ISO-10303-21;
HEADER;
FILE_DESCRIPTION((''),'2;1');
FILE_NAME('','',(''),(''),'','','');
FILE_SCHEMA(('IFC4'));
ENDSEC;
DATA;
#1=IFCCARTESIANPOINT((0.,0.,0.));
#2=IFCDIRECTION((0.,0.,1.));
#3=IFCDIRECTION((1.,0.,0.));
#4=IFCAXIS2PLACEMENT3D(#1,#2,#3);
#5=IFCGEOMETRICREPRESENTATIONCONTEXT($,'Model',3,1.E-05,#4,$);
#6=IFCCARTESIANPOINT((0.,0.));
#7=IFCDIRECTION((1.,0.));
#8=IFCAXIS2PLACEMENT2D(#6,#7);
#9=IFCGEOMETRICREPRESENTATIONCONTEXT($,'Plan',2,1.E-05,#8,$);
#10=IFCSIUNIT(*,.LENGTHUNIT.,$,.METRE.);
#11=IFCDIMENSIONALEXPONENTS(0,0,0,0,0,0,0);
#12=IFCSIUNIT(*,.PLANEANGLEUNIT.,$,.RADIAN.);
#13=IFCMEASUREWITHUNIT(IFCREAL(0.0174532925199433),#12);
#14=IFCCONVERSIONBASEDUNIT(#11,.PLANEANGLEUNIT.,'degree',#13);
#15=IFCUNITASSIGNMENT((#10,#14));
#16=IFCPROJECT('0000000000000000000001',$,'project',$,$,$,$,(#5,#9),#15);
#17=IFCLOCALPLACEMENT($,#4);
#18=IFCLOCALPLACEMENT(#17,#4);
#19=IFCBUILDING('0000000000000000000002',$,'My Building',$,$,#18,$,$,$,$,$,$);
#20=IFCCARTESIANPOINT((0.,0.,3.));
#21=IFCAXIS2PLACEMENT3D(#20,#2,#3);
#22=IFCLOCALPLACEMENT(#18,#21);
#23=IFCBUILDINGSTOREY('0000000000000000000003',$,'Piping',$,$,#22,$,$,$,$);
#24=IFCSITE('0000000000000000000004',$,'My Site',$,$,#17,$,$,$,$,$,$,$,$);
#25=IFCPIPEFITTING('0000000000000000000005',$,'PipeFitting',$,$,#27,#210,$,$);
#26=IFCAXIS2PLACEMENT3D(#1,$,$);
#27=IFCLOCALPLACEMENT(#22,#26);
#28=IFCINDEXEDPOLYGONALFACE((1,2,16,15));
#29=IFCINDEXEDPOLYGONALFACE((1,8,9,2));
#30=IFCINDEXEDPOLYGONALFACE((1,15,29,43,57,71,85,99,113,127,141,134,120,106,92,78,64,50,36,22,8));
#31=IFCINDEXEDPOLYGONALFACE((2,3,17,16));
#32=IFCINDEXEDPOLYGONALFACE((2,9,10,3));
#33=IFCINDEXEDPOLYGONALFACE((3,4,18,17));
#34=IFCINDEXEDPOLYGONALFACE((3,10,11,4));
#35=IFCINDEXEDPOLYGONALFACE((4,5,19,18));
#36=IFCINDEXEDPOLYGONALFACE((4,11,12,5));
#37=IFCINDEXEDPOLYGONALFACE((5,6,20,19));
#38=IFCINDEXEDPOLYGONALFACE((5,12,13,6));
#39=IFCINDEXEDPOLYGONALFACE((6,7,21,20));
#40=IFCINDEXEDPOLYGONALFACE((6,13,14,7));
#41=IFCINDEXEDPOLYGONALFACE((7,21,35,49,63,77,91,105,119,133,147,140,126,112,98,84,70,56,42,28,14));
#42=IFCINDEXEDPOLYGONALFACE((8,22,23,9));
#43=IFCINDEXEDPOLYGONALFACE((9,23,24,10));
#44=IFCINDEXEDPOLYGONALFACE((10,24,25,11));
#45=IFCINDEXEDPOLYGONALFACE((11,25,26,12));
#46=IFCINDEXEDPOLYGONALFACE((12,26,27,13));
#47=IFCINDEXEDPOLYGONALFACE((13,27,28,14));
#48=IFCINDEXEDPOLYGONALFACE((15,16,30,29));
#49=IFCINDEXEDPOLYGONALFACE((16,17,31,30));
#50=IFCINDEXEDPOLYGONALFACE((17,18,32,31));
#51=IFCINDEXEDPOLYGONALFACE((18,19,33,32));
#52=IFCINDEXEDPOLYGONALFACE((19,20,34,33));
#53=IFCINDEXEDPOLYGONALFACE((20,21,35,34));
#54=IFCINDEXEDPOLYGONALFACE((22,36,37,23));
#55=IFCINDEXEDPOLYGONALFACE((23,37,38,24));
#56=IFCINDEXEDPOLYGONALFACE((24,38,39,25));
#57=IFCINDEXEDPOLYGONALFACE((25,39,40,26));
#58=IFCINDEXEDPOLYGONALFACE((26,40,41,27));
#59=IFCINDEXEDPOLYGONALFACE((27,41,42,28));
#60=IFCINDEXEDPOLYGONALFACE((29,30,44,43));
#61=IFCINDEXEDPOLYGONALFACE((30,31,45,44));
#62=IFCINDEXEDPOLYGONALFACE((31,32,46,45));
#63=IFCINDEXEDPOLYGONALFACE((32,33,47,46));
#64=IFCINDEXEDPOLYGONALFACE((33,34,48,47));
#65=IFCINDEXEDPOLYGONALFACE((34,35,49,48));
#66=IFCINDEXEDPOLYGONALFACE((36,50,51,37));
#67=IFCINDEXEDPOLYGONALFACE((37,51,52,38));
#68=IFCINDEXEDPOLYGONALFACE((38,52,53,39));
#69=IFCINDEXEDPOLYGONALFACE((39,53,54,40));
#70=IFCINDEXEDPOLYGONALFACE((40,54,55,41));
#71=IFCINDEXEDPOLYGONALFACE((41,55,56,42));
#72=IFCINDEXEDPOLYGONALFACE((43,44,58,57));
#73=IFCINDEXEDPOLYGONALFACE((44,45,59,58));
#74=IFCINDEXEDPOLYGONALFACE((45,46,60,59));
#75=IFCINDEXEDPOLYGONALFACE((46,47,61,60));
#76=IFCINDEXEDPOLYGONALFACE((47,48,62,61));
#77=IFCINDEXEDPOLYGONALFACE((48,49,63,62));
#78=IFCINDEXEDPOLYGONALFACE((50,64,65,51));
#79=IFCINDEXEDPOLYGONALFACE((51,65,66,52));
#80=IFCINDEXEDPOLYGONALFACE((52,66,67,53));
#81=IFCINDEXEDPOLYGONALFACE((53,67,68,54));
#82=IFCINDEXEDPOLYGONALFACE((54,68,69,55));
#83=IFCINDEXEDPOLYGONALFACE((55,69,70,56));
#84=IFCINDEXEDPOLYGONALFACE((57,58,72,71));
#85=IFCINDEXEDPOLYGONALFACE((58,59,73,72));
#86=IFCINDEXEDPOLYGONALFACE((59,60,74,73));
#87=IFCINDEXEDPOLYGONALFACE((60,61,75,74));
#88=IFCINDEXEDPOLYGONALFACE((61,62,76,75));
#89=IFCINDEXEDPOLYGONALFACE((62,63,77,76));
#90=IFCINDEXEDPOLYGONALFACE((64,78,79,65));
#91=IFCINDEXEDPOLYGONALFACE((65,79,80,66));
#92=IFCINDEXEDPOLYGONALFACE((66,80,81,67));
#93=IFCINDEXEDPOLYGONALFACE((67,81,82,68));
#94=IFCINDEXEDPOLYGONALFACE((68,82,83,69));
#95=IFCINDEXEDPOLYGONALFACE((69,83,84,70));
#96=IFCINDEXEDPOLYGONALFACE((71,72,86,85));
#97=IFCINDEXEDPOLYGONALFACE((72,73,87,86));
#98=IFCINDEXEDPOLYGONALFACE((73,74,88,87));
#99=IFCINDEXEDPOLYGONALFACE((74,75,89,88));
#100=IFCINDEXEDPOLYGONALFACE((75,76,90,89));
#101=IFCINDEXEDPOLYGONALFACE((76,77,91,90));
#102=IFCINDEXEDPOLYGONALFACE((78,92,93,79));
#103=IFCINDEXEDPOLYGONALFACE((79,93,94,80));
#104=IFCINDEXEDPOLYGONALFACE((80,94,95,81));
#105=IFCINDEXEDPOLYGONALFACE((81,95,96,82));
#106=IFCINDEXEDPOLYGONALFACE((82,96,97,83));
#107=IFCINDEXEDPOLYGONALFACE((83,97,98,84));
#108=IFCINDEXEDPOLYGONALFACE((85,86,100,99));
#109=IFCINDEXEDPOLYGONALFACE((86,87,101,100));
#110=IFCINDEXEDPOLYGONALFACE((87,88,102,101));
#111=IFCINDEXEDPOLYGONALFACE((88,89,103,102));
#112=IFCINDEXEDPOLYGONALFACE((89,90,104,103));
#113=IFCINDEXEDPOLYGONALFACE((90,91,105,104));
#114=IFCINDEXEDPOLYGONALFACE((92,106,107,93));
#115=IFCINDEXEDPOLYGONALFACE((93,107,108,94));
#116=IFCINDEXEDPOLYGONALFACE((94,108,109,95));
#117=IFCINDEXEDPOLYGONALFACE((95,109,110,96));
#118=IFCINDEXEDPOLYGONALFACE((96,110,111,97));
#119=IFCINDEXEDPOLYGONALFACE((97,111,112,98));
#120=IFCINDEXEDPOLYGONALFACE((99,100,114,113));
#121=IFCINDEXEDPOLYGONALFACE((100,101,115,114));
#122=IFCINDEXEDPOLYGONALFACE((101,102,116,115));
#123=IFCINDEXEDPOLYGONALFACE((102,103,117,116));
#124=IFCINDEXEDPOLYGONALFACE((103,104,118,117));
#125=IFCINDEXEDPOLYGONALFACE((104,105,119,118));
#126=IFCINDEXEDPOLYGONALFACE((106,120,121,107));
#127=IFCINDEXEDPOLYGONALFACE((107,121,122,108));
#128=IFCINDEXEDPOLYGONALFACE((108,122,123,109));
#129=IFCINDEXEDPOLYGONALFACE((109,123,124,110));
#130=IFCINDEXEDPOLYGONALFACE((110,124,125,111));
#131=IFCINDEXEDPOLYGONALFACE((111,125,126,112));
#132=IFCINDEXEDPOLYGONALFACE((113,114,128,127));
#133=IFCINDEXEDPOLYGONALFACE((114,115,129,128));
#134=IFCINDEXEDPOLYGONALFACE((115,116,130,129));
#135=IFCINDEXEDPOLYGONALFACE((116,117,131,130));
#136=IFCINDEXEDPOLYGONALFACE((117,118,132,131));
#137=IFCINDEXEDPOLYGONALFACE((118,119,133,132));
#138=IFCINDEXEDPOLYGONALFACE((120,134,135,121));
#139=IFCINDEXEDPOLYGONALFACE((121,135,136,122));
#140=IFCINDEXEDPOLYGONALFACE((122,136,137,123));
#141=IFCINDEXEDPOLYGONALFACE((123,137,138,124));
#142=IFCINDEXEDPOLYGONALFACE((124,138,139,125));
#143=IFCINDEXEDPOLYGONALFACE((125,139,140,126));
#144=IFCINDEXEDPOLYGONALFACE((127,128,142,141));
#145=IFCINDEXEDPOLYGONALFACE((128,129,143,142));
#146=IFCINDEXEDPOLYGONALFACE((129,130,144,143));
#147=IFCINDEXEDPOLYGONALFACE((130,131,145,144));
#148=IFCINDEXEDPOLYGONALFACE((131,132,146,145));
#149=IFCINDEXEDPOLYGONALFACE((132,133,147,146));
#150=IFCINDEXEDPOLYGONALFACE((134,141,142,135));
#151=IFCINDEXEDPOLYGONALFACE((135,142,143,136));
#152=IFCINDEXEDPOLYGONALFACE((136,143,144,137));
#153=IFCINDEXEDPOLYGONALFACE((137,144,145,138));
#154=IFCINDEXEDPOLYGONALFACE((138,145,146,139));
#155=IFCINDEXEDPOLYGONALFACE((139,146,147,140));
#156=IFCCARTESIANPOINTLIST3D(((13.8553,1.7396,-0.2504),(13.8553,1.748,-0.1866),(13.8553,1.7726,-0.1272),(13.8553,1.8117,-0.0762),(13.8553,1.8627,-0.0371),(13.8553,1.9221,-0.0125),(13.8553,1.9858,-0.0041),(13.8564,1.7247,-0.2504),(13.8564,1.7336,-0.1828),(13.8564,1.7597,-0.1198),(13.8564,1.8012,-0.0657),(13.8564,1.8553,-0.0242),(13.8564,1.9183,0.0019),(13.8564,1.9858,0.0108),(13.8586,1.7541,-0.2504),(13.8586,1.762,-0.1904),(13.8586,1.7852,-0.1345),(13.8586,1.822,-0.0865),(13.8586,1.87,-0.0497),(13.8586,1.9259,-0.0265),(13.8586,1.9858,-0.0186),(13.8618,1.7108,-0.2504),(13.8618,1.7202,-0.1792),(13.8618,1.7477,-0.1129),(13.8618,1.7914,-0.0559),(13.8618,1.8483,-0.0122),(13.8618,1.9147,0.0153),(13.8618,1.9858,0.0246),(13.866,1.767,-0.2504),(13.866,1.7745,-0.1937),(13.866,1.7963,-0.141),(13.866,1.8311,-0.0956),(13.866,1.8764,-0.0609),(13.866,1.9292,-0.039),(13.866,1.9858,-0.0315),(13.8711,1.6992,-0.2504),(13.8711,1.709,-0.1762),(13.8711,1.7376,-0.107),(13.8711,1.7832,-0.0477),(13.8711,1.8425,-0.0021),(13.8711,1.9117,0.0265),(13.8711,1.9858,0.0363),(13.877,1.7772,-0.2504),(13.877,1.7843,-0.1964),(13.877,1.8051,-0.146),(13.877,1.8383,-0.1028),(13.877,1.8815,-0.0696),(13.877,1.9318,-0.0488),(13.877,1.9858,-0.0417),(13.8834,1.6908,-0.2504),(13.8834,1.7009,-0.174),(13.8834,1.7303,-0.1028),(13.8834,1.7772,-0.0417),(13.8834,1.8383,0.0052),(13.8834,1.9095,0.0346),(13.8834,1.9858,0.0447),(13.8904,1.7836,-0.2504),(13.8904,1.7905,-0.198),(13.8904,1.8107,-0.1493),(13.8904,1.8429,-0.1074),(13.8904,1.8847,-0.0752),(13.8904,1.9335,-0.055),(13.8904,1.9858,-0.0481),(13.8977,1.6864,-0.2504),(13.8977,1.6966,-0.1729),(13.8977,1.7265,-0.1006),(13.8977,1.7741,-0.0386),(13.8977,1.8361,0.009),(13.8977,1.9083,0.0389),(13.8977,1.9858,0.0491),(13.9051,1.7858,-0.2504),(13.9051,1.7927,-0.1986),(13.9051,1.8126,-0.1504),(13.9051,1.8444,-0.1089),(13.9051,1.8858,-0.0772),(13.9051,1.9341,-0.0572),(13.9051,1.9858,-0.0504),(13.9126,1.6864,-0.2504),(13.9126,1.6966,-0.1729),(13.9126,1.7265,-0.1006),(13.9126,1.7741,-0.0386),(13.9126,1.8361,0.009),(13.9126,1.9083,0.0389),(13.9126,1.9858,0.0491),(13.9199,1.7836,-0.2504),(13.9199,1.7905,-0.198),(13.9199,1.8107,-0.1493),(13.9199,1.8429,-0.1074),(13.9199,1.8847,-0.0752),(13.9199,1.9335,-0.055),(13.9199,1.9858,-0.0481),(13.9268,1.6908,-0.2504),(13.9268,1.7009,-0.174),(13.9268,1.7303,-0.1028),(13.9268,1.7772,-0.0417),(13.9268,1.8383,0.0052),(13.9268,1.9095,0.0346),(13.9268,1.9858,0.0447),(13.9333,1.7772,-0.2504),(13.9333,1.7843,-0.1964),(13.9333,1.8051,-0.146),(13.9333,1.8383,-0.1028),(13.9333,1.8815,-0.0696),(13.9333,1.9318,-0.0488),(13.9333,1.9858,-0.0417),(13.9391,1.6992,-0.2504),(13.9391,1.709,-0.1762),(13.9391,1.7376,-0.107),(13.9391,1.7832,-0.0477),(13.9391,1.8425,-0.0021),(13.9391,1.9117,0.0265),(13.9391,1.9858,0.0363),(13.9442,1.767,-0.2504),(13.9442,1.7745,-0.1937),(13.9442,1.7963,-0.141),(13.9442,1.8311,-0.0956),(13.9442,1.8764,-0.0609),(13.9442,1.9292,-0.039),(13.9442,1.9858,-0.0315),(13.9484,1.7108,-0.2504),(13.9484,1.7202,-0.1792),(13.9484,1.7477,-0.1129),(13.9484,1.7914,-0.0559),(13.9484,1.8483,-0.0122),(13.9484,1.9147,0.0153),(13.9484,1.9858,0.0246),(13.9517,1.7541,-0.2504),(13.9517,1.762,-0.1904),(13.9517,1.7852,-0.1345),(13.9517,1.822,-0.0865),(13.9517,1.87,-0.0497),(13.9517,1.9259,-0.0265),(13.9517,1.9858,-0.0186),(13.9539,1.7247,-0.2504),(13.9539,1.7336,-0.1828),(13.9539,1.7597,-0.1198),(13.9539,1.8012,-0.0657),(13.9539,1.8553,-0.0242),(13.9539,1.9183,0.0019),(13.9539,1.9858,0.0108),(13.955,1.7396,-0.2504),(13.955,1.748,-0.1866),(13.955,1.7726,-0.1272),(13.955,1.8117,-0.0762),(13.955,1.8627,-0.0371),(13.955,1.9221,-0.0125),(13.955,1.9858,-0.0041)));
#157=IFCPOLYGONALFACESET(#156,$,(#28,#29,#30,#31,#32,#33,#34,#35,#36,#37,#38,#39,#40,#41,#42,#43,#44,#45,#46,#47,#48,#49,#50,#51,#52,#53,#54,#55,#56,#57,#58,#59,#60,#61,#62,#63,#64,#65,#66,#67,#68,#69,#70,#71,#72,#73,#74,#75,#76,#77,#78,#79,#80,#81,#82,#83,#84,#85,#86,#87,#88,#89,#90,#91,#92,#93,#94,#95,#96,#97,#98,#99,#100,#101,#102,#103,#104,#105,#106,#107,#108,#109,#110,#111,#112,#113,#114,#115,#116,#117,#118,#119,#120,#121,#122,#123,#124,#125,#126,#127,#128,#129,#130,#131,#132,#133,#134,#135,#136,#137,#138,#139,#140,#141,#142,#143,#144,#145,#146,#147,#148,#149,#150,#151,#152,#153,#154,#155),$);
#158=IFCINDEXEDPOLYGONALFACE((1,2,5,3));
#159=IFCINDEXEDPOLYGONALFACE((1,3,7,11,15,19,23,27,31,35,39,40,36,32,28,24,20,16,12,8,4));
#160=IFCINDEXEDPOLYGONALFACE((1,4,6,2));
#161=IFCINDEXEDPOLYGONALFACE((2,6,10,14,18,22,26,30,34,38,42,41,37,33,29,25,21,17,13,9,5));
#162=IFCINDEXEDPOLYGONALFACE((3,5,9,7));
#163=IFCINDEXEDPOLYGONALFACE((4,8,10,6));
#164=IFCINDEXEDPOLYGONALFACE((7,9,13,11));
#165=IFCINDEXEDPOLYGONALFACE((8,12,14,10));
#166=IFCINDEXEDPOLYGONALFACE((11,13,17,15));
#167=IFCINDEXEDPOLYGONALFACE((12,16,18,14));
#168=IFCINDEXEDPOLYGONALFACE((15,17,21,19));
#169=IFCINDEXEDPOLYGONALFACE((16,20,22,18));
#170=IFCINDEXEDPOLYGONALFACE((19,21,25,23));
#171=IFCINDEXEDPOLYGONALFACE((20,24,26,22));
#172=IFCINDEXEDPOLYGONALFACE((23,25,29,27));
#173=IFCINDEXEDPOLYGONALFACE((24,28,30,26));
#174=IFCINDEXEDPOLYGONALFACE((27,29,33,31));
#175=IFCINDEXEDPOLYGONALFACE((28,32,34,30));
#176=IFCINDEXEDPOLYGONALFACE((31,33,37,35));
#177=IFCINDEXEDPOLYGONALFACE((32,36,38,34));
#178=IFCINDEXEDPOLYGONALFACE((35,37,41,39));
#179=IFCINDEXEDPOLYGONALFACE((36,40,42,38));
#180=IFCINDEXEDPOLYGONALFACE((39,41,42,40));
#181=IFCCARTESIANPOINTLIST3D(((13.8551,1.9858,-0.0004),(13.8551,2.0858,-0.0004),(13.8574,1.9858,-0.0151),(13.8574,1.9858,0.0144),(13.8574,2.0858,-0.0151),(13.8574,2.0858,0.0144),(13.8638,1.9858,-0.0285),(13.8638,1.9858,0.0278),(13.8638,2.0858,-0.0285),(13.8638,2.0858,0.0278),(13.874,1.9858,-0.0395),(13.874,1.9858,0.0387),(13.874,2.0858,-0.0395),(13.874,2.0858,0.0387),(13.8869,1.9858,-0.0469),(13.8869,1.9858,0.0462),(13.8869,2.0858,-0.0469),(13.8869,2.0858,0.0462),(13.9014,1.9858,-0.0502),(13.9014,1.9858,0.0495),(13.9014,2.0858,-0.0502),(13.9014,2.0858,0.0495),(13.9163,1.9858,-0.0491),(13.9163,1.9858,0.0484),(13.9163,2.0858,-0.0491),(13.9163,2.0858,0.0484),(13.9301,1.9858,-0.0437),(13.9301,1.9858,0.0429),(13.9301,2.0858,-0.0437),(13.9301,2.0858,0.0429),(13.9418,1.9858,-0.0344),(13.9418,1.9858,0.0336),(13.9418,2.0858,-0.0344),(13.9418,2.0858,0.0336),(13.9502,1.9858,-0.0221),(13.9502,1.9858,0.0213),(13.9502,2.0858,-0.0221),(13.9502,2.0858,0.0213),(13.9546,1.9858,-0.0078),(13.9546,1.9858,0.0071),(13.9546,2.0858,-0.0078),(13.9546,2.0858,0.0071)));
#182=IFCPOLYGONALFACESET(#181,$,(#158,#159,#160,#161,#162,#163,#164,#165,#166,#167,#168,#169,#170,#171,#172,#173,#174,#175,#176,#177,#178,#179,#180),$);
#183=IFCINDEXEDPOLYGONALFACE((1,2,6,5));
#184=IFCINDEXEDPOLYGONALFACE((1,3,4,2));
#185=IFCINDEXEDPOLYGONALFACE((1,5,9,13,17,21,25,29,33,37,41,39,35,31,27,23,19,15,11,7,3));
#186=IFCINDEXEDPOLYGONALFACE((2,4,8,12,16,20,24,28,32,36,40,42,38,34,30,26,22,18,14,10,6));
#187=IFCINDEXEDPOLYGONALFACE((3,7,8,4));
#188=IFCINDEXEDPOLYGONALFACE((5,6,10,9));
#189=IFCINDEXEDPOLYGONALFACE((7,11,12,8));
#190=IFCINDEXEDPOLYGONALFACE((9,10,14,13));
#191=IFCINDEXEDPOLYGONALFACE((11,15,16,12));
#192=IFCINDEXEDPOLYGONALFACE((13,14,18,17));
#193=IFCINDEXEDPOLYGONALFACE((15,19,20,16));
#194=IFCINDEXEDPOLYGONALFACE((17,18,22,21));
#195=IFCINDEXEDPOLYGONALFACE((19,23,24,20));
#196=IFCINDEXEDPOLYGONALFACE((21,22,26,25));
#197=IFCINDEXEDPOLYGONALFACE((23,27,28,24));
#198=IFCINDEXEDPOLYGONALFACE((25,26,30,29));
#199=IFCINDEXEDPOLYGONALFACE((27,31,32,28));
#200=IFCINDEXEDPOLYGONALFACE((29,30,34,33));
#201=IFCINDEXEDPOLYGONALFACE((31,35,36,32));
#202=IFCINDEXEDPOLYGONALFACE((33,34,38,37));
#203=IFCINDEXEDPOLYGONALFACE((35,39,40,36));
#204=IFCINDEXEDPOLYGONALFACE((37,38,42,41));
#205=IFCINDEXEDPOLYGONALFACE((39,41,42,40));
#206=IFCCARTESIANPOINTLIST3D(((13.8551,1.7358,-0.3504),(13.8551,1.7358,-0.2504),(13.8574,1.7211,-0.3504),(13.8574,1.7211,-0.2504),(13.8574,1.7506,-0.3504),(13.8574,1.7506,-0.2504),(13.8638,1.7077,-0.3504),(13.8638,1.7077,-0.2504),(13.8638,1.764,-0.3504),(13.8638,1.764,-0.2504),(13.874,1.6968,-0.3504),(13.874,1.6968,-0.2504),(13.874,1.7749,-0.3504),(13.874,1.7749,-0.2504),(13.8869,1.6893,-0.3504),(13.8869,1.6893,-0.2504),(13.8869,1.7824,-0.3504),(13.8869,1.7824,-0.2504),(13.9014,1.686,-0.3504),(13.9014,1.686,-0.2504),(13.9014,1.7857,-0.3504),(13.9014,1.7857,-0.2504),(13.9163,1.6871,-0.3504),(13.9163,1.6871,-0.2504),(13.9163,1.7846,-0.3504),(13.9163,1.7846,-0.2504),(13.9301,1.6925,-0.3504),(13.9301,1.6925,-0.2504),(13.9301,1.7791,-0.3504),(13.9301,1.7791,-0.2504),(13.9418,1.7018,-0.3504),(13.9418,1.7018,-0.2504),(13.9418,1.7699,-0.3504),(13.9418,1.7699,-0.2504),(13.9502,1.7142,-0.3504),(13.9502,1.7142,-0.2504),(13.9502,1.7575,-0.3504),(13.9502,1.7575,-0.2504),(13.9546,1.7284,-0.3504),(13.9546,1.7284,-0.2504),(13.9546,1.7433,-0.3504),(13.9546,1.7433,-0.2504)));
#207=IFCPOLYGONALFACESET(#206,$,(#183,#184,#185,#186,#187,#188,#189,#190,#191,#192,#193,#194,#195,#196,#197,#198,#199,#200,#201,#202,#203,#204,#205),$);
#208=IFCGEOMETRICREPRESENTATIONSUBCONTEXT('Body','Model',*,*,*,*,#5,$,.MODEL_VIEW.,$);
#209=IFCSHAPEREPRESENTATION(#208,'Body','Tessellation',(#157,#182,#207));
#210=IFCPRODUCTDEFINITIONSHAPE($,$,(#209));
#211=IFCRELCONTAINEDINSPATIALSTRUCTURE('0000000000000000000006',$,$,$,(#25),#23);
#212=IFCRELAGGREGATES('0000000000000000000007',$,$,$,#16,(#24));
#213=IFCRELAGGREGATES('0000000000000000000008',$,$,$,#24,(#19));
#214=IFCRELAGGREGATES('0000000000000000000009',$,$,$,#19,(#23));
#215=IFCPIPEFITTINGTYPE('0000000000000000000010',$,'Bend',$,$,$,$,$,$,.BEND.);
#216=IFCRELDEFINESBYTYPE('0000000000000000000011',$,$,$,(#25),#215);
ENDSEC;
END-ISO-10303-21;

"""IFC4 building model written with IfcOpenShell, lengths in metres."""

from ifc_helpers import new_model, entity, si_unit, converted_unit, frame, origin_with_axes, origin_2d_with_axis, place, context, subcontext, project, spatial, circle, extrude, source, transform, mapped, type_object, type_shapes, element, save


model = new_model("IFC4")

# Units and contexts
model_context = context("Model", 3, precision=1e-05, world=origin_with_axes())
plan_context = context("Plan", 2, precision=1e-05, world=origin_2d_with_axis())
body_context = subcontext(model_context, "Body", "Model", "MODEL_VIEW")
ifc_project = project(units=[si_unit("LENGTHUNIT", "METRE"), converted_unit("PLANEANGLEUNIT", "degree", entity("IfcReal", 0.0174532925199433), si_unit("PLANEANGLEUNIT", "RADIAN"), dimensions=[0, 0, 0, 0, 0, 0, 0])], contexts=[model_context, plan_context])

# Site, building, storey
site_placement = place(None, origin_with_axes())
site = spatial("IfcSite", under=ifc_project, at=site_placement, Name="My Site")
building_placement = place(site_placement, origin_with_axes())
building = spatial("IfcBuilding", under=site, at=building_placement, Name="My Building")
storey_placement = place(building_placement, frame((0.0, 0.0, 3.0), z_axis=(0.0, 0.0, 1.0), x_axis=(1.0, 0.0, 0.0)))
storey = spatial("IfcBuildingStorey", under=building, at=storey_placement, Name="Piping")

# Shared definitions
pipe_fitting_type = type_object("IfcPipeFittingType", Name="Bend", PredefinedType="BEND")
shared_shape = source(origin_with_axes(), body_context, "Body", "SolidModel", [
    entity("IfcSweptDiskSolid", entity("IfcIndexedPolyCurve", entity("IfcCartesianPointList3D", [[0.0, 0.0, -0.1], [0.0, -0.0732, -0.2768], [0.0, -0.25, -0.35]]), [entity("IfcArcIndex", [1, 2, 3])]), 0.05),
    extrude(circle(Radius=0.05), origin_with_axes(), (0.0, 0.0, -1.0), 0.1),
    extrude(circle(Radius=0.05), frame((0.0, -0.25, -0.35), z_axis=(0.0, -1.0, 0.0), x_axis=(1.0, 0.0, 0.0)), (0.0, 0.0, 1.0), 0.1),
])
type_shapes(pipe_fitting_type, [shared_shape])

# Pipe fitting
for number, where, z_axis, x_axis, name in (
    (1, (13.9051, 2.0858, -0.0004), (0.0, 1.0, 0.0), (-1.0, 0.0, 0.0), "PipeFitting"),
):
    element("IfcPipeFitting", number, at=place(storey_placement, frame(where, z_axis=z_axis, x_axis=x_axis)), inside=storey, type_object=pipe_fitting_type, Name=name, context=body_context, shape_type="MappedRepresentation", body=[
        mapped(shared_shape, transform((0.0, 0.0, 0.0), x_axis=(1.0, 0.0, 0.0), y_axis=(0.0, 1.0, 0.0), z_axis=(0.0, 0.0, 1.0), scale=1.0)),
    ])

save(model, "model.ifc")
